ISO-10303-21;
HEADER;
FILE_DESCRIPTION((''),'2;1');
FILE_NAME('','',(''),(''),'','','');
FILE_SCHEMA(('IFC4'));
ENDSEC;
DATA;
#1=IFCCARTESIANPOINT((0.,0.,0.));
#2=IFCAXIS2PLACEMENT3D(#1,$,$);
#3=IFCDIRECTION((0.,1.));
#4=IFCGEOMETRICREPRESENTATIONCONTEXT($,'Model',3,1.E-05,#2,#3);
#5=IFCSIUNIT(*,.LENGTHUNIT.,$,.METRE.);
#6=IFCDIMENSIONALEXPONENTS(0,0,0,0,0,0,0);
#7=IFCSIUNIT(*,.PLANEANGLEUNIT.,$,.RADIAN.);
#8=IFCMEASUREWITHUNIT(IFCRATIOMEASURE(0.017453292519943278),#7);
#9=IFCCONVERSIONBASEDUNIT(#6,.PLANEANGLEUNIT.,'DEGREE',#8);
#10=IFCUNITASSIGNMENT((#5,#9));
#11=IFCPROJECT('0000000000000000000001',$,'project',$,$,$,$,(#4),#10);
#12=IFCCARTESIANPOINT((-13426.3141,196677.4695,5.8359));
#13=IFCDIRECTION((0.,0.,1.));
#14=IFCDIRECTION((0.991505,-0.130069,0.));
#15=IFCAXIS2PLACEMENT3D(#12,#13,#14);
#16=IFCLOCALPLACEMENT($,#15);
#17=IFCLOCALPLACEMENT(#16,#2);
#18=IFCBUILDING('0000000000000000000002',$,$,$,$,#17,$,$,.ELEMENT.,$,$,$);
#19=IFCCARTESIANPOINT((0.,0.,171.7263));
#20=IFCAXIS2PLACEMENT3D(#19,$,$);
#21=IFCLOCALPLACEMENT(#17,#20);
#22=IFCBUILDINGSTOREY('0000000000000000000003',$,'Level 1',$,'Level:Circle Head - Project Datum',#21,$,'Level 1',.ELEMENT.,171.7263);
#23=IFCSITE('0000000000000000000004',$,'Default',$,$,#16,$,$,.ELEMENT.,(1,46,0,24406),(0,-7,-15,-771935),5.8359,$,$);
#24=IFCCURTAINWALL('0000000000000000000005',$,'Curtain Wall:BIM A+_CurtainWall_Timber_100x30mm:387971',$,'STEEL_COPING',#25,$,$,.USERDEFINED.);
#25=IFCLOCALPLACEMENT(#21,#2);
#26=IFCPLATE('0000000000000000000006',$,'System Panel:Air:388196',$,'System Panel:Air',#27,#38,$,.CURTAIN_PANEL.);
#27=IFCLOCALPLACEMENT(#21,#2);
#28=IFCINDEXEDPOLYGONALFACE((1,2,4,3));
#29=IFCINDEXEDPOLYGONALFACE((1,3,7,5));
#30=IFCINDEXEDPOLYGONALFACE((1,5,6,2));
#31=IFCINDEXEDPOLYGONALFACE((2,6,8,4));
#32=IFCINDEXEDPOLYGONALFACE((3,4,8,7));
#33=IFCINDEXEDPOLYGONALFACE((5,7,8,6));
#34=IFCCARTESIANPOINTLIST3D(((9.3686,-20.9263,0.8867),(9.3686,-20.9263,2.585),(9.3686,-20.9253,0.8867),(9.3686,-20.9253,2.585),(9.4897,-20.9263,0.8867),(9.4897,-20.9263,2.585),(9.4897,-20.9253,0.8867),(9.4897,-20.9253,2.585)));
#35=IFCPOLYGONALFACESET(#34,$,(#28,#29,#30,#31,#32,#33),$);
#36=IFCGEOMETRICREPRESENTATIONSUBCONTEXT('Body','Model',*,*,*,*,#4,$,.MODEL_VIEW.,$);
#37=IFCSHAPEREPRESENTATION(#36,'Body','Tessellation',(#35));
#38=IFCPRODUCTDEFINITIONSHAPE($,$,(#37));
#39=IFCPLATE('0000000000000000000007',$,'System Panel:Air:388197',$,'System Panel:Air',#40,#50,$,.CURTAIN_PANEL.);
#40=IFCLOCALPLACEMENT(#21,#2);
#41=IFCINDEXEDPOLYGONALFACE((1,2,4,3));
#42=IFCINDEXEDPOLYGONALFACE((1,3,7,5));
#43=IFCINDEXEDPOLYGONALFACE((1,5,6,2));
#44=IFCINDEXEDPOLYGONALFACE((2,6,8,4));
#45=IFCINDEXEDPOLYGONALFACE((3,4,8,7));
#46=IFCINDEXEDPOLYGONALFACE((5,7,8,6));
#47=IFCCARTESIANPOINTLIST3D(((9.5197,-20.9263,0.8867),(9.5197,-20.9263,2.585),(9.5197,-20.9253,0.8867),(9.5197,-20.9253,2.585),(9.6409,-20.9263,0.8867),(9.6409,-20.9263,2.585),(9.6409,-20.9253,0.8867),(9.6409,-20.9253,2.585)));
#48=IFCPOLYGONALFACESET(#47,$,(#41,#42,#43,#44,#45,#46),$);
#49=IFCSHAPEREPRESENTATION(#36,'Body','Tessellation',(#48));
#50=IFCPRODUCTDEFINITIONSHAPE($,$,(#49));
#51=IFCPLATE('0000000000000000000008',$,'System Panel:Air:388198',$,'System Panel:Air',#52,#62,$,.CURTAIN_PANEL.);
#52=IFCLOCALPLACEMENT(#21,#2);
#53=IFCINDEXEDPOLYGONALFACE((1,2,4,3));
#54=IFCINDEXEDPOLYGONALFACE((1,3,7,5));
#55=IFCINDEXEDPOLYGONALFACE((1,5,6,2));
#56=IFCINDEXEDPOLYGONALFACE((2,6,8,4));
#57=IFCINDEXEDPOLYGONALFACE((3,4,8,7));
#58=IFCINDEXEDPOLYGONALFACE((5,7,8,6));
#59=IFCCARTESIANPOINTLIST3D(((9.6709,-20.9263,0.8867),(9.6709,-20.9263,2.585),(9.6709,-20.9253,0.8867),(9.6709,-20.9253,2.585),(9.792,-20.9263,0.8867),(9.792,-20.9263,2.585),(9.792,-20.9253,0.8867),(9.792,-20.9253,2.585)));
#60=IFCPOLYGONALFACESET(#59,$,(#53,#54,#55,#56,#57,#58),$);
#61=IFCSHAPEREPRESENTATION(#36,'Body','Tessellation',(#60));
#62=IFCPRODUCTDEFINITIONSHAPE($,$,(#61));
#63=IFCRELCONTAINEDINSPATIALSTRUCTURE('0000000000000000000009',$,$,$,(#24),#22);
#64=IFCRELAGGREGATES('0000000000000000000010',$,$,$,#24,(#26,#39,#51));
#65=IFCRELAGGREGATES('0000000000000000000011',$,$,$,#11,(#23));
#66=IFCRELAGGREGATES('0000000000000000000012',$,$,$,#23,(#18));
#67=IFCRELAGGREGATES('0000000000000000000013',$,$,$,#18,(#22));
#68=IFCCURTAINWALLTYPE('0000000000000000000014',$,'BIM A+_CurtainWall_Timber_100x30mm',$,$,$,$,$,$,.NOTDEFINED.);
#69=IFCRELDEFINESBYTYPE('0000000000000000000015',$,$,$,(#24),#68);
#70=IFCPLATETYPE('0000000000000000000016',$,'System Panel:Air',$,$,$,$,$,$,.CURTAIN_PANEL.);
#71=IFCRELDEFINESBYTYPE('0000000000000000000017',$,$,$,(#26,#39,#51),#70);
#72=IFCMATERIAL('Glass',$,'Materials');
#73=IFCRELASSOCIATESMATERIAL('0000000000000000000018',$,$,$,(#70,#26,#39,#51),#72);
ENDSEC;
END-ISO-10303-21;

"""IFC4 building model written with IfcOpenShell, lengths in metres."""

from ifc_helpers import new_model, entity, si_unit, converted_unit, direction, frame, origin, place, context, subcontext, project, spatial, indexed_curve, outline, extrude, source, transform, mapped, material, type_object, type_shapes, element, aggregate, save


model = new_model("IFC4")

# Units and contexts
model_context = context("Model", 3, precision=1e-05, world=origin(), true_north=direction((0.0, 1.0)))
body_context = subcontext(model_context, "Body", "Model", "MODEL_VIEW")
ifc_project = project(units=[si_unit("LENGTHUNIT", "METRE"), converted_unit("PLANEANGLEUNIT", "DEGREE", entity("IfcRatioMeasure", 0.017453292519943278), si_unit("PLANEANGLEUNIT", "RADIAN"), dimensions=[0, 0, 0, 0, 0, 0, 0])], contexts=[model_context])

# Site, building, storey
site_placement = place(None, frame((-13426.3141, 196677.4695, 5.8359), z_axis=(0.0, 0.0, 1.0), x_axis=(0.991505, -0.130069, 0.0)))
site = spatial("IfcSite", under=ifc_project, at=site_placement, Name="Default", CompositionType="ELEMENT", RefLatitude=(1, 46, 0, 24406), RefLongitude=(0, -7, -15, -771935), RefElevation=5.8359)
building_placement = place(site_placement, origin())
building = spatial("IfcBuilding", under=site, at=building_placement, CompositionType="ELEMENT")
storey_placement = place(building_placement, frame((0.0, 0.0, 171.7263)))
storey = spatial("IfcBuildingStorey", under=building, at=storey_placement, Name="Level 1", ObjectType="Level:Circle Head - Project Datum", LongName="Level 1", CompositionType="ELEMENT", Elevation=171.7263)

# Curtain wall
curtain_wall_type_1 = type_object("IfcCurtainWallType", Name="BIM A+_CurtainWall_Timber_100x30mm", PredefinedType="NOTDEFINED")
curtain_wall_1_placement = place(storey_placement, frame((0.0, 0.0, -171.7263)))
curtain_wall_1 = element("IfcCurtainWall", 1, at=curtain_wall_1_placement, inside=storey, type_object=curtain_wall_type_1, Name="Curtain Wall:BIM A+_CurtainWall_Timber_100x30mm:387971", ObjectType="STEEL_COPING", PredefinedType="USERDEFINED")

# Plates
ifc_material_1 = material(Name="Glass", Category="Materials")
plate_type_1 = type_object("IfcPlateType", Name="System Panel:Air", PredefinedType="CURTAIN_PANEL", material=ifc_material_1)
shared_shape_1 = source(origin(), body_context, "Body", "SweptSolid", [
    extrude(outline(indexed_curve([(-0.0005, -0.0606), (0.0005, -0.0606), (0.0005, 0.0606), (-0.0005, 0.0606), (-0.0005, -0.0606)], self_intersect=False)), frame((0.0, 0.0, 0.0), z_axis=(0.0, 0.0, 1.0), x_axis=(0.0, 1.0, 0.0)), (0.0, 0.0, 1.0), 1.6983),
])
type_shapes(plate_type_1, [shared_shape_1])
plate_1_placement = place(curtain_wall_1_placement, frame((9.4291, -20.9258, 172.613)))
plate_1 = element("IfcPlate", 2, at=plate_1_placement, type_object=plate_type_1, material=ifc_material_1, Name="System Panel:Air:388196", ObjectType="System Panel:Air", PredefinedType="CURTAIN_PANEL", context=body_context, shape_type="MappedRepresentation", body=[
    mapped(shared_shape_1, transform((0.0, 0.0, 0.0), scale=1.0)),
])
plate_2_placement = place(curtain_wall_1_placement, frame((9.5803, -20.9258, 172.613)))
plate_2 = element("IfcPlate", 3, at=plate_2_placement, type_object=plate_type_1, material=ifc_material_1, Name="System Panel:Air:388197", ObjectType="System Panel:Air", PredefinedType="CURTAIN_PANEL", context=body_context, shape_type="MappedRepresentation", body=[
    mapped(shared_shape_1, transform((0.0, 0.0, 0.0), scale=1.0)),
])
plate_3_placement = place(curtain_wall_1_placement, frame((9.7315, -20.9258, 172.613)))
plate_3 = element("IfcPlate", 4, at=plate_3_placement, type_object=plate_type_1, material=ifc_material_1, Name="System Panel:Air:388198", ObjectType="System Panel:Air", PredefinedType="CURTAIN_PANEL", context=body_context, shape_type="MappedRepresentation", body=[
    mapped(shared_shape_1, transform((0.0, 0.0, 0.0), scale=1.0)),
])
aggregate(curtain_wall_1, [plate_1, plate_2, plate_3])

save(model, "model.ifc")
